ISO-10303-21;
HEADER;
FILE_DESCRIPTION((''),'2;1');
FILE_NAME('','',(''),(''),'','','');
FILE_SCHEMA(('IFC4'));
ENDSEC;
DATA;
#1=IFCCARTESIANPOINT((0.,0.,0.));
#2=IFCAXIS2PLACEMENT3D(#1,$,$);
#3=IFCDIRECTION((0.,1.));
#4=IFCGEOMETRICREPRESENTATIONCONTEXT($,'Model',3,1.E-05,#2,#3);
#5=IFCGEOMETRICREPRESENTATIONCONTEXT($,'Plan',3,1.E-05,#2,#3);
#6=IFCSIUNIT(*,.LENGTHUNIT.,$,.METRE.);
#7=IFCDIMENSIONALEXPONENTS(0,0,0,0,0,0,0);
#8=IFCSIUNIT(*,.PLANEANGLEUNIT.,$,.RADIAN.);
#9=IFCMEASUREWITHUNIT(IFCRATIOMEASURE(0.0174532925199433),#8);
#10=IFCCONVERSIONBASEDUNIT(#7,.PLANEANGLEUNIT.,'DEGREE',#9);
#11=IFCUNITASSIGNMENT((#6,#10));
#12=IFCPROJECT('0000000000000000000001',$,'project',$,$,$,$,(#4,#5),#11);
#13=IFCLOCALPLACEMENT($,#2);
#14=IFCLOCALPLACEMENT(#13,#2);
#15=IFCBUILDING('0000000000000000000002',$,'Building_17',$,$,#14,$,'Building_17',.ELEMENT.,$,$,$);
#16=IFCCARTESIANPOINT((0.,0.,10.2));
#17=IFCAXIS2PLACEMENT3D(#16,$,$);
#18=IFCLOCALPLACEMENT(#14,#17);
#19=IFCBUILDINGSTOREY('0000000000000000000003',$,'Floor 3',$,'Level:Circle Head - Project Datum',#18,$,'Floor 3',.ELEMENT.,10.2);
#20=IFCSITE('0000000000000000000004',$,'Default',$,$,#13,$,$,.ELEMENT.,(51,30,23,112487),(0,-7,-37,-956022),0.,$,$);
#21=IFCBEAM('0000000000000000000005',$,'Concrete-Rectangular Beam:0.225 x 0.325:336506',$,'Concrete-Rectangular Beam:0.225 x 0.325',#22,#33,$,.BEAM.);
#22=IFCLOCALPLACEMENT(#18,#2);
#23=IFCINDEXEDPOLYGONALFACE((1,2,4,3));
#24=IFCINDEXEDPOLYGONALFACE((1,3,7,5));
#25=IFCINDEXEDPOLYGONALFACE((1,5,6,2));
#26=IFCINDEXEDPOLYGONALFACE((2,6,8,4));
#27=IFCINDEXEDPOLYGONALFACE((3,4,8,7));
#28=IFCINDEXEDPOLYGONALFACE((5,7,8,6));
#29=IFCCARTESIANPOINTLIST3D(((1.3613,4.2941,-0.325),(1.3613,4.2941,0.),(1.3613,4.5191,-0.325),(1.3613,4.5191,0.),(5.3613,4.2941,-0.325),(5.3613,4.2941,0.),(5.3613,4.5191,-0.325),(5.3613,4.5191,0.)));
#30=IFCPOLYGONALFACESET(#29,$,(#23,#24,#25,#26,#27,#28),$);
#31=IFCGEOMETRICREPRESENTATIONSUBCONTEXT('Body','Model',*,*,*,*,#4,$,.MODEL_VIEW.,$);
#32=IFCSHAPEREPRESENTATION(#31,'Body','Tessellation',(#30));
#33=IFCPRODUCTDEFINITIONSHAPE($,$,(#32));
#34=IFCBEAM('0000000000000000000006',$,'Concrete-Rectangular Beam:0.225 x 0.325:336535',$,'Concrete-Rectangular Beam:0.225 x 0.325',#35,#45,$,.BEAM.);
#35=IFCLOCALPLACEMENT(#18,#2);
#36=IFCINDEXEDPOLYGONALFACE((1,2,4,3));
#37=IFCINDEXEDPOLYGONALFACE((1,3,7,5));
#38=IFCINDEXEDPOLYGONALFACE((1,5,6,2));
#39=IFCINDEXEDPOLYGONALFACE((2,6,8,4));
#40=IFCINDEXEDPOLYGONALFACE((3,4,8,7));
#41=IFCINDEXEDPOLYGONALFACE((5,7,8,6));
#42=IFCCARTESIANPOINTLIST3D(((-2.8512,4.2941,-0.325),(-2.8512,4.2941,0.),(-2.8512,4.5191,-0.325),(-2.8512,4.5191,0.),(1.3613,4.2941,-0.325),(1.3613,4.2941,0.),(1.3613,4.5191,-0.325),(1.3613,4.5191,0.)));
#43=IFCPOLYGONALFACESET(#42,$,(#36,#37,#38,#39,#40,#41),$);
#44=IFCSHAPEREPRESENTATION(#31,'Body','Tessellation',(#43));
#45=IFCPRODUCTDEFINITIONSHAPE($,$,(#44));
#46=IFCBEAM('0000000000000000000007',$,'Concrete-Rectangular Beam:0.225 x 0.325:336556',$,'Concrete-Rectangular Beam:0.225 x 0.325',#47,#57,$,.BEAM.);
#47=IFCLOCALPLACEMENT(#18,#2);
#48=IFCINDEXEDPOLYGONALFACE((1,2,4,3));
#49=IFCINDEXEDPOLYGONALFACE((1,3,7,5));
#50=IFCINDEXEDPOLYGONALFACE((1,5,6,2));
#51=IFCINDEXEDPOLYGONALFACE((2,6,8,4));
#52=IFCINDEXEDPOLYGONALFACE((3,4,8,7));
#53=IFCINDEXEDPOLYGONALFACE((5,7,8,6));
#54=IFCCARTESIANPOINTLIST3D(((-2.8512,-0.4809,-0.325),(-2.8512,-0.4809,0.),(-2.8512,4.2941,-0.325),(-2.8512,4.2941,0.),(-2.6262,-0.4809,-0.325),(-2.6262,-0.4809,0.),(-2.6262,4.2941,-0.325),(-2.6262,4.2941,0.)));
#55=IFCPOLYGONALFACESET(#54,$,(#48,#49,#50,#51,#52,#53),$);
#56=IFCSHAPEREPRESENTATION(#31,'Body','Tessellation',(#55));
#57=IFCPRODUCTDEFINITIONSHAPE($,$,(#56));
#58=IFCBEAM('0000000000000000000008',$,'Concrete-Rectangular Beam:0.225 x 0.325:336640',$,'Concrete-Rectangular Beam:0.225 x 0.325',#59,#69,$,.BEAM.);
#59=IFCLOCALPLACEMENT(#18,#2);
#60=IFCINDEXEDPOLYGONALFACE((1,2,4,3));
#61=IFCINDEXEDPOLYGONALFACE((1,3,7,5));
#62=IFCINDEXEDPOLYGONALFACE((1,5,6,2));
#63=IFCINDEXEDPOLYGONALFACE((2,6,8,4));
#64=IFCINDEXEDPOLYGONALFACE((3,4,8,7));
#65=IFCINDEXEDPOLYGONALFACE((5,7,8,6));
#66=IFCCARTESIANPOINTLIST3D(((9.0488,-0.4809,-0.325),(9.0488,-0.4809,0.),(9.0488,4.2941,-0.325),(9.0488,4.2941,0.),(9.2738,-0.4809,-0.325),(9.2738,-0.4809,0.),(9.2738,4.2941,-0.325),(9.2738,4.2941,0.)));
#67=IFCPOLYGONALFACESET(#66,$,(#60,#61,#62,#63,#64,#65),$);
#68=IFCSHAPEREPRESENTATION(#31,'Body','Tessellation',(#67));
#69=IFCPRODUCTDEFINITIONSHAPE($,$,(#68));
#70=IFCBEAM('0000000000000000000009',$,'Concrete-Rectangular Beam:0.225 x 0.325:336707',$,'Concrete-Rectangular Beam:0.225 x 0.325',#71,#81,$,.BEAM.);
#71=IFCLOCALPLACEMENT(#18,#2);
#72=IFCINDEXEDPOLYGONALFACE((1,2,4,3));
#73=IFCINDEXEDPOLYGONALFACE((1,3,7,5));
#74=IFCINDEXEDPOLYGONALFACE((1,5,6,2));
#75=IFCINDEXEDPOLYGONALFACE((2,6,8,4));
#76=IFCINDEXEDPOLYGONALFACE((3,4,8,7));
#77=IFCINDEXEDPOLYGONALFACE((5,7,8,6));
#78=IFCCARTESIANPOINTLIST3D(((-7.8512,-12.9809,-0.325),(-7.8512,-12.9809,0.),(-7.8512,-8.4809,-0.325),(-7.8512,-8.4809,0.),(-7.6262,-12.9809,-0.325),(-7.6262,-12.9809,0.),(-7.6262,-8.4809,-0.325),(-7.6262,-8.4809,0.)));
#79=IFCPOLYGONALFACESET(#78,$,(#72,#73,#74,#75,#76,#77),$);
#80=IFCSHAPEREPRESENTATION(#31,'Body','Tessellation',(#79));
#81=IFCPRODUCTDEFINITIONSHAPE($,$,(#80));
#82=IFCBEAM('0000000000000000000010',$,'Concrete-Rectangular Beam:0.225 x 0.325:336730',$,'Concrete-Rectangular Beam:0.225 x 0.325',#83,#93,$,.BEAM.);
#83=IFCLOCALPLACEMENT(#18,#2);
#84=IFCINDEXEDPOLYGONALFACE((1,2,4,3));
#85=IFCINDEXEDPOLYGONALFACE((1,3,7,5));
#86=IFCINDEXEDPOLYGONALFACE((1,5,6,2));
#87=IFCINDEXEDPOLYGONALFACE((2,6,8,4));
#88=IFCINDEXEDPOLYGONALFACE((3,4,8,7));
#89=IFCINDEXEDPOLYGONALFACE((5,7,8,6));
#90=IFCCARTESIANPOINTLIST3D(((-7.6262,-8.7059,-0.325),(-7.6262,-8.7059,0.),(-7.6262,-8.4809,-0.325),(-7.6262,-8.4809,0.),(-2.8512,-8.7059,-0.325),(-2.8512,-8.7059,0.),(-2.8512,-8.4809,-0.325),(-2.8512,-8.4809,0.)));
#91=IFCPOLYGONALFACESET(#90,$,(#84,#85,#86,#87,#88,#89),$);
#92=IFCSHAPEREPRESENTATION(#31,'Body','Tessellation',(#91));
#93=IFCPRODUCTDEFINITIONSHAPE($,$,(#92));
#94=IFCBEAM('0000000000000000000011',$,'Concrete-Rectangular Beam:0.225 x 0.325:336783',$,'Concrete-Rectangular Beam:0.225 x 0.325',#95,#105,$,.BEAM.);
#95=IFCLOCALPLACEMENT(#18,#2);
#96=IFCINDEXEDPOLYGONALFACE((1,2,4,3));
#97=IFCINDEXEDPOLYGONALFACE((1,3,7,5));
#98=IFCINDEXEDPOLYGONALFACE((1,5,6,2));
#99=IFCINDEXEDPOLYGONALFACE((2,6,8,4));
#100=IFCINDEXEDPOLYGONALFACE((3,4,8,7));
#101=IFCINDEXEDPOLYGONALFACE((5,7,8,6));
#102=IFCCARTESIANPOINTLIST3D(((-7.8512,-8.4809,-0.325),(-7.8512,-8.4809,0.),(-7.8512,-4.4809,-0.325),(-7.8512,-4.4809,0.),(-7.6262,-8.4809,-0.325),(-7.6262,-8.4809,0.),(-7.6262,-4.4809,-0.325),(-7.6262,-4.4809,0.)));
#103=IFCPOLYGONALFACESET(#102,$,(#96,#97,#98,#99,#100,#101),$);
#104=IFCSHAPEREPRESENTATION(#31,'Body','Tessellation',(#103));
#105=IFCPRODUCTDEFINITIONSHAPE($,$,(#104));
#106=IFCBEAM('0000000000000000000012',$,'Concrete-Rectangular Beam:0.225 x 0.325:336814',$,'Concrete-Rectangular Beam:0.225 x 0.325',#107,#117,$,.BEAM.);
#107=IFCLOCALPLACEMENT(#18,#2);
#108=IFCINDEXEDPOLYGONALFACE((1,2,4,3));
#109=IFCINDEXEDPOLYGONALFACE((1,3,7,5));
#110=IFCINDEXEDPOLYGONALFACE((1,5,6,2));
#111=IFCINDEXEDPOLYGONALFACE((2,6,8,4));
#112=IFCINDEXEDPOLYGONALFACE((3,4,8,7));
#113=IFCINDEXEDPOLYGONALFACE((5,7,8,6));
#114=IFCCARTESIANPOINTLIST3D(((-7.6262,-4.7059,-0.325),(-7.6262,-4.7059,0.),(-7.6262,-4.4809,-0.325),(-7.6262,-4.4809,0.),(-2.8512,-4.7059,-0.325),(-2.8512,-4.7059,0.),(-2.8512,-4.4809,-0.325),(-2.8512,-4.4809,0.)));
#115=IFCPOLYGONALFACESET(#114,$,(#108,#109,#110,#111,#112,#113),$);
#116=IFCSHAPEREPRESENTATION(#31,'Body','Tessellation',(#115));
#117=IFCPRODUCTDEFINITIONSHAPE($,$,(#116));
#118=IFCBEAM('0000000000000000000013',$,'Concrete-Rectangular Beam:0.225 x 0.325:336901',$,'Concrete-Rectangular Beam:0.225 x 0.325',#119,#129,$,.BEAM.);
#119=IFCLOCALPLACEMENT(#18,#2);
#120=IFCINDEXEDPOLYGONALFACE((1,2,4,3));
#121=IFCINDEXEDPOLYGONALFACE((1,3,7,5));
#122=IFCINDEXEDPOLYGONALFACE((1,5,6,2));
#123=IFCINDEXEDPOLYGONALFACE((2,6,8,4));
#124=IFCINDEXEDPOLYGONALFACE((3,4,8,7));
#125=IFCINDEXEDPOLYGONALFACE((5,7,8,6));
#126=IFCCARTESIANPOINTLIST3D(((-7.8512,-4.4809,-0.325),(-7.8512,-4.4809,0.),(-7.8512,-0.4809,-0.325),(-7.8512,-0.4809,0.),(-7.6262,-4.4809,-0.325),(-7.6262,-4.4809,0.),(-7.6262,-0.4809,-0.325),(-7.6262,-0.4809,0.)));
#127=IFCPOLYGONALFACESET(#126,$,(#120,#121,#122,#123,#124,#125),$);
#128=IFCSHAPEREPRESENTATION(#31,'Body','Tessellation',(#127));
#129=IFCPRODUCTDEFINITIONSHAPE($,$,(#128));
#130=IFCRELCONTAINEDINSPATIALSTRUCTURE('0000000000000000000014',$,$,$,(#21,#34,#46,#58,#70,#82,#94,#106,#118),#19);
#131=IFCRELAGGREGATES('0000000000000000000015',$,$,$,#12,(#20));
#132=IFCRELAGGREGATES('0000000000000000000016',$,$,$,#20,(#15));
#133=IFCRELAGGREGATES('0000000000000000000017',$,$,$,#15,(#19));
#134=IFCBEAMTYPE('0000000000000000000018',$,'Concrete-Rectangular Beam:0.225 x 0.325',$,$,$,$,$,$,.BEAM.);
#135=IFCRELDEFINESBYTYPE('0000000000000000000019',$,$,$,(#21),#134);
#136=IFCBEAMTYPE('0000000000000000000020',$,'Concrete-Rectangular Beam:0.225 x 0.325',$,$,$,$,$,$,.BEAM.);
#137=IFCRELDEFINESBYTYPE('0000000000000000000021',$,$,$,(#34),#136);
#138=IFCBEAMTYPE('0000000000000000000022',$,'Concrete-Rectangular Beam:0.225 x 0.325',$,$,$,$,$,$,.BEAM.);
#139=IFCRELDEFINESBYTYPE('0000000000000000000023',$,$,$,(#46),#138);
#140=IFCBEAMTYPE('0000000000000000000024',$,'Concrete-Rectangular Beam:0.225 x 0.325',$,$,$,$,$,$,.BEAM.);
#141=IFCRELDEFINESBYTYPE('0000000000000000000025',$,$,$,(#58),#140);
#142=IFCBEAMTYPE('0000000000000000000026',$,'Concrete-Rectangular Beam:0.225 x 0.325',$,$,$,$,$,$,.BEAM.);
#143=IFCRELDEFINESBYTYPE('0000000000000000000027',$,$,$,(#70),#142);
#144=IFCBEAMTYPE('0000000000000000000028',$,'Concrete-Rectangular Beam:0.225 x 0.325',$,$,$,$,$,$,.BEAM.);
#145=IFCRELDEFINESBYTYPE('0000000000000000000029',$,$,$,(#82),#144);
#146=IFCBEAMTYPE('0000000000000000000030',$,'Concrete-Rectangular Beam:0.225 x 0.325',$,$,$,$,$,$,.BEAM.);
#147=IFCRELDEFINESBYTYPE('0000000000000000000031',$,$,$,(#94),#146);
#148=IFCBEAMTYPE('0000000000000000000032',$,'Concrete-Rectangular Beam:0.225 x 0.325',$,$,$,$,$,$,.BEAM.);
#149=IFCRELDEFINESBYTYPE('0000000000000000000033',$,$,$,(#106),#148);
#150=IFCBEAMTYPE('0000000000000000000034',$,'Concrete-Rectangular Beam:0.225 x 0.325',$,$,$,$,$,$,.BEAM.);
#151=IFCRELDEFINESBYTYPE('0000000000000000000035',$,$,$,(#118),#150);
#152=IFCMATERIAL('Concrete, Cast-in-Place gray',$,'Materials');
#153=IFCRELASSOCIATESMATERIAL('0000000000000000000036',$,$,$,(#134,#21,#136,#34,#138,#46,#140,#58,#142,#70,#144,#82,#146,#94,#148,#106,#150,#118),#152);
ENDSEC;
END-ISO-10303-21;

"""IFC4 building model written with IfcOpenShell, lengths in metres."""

from ifc_helpers import new_model, entity, si_unit, converted_unit, direction, frame, origin, place, context, subcontext, project, spatial, indexed_curve, outline, extrude, source, transform, mapped, material, type_object, type_shapes, element, save


model = new_model("IFC4")

# Units and contexts
model_context = context("Model", 3, precision=1e-05, world=origin(), true_north=direction((0.0, 1.0)))
plan_context = context("Plan", 3, precision=1e-05, world=origin(), true_north=direction((0.0, 1.0)))
body_context = subcontext(model_context, "Body", "Model", "MODEL_VIEW")
ifc_project = project(units=[si_unit("LENGTHUNIT", "METRE"), converted_unit("PLANEANGLEUNIT", "DEGREE", entity("IfcRatioMeasure", 0.0174532925199433), si_unit("PLANEANGLEUNIT", "RADIAN"), dimensions=[0, 0, 0, 0, 0, 0, 0])], contexts=[model_context, plan_context])

# Site, building, storey
site_placement = place(None, origin())
site = spatial("IfcSite", under=ifc_project, at=site_placement, Name="Default", CompositionType="ELEMENT", RefLatitude=(51, 30, 23, 112487), RefLongitude=(0, -7, -37, -956022), RefElevation=0.0)
building_placement = place(site_placement, origin())
building = spatial("IfcBuilding", under=site, at=building_placement, Name="Building_17", LongName="Building_17", CompositionType="ELEMENT")
storey_placement = place(building_placement, frame((0.0, 0.0, 10.2)))
storey = spatial("IfcBuildingStorey", under=building, at=storey_placement, Name="Floor 3", ObjectType="Level:Circle Head - Project Datum", LongName="Floor 3", CompositionType="ELEMENT", Elevation=10.2)

# Beams
ifc_material_1 = material(Name="Concrete, Cast-in-Place gray", Category="Materials")
beam_type_1 = type_object("IfcBeamType", Name="Concrete-Rectangular Beam:0.225 x 0.325", PredefinedType="BEAM", material=ifc_material_1)
shared_shape_1 = source(origin(), body_context, "Body", "SweptSolid", [
    extrude(outline(indexed_curve([(-0.1625, -0.1125), (0.1625, -0.1125), (0.1625, 0.1125), (-0.1625, 0.1125), (-0.1625, -0.1125)], self_intersect=False)), frame((5.3613, 4.4066, 10.0375), z_axis=(-1.0, 0.0, 0.0), x_axis=(0.0, 0.0, -1.0)), (0.0, 0.0, 1.0), 4.0),
])
type_shapes(beam_type_1, [shared_shape_1])
beam_1_placement = place(storey_placement, frame((0.0, 0.0, -10.2)))
element("IfcBeam", 1, at=beam_1_placement, inside=storey, type_object=beam_type_1, material=ifc_material_1, Name="Concrete-Rectangular Beam:0.225 x 0.325:336506", ObjectType="Concrete-Rectangular Beam:0.225 x 0.325", PredefinedType="BEAM", context=body_context, shape_type="MappedRepresentation", body=[
    mapped(shared_shape_1, transform((0.0, 0.0, 0.0), scale=1.0)),
])
beam_type_2 = type_object("IfcBeamType", Name="Concrete-Rectangular Beam:0.225 x 0.325", PredefinedType="BEAM", material=ifc_material_1)
shared_shape_2 = source(origin(), body_context, "Body", "SweptSolid", [
    extrude(outline(indexed_curve([(-0.1625, -0.1125), (0.1625, -0.1125), (0.1625, 0.1125), (-0.1625, 0.1125), (-0.1625, -0.1125)], self_intersect=False)), frame((1.3613, 4.4066, 10.0375), z_axis=(-1.0, 0.0, 0.0), x_axis=(0.0, 0.0, -1.0)), (0.0, 0.0, 1.0), 4.2125),
])
type_shapes(beam_type_2, [shared_shape_2])
beam_2_placement = place(storey_placement, frame((0.0, 0.0, -10.2)))
element("IfcBeam", 2, at=beam_2_placement, inside=storey, type_object=beam_type_2, material=ifc_material_1, Name="Concrete-Rectangular Beam:0.225 x 0.325:336535", ObjectType="Concrete-Rectangular Beam:0.225 x 0.325", PredefinedType="BEAM", context=body_context, shape_type="MappedRepresentation", body=[
    mapped(shared_shape_2, transform((0.0, 0.0, 0.0), scale=1.0)),
])
beam_type_3 = type_object("IfcBeamType", Name="Concrete-Rectangular Beam:0.225 x 0.325", PredefinedType="BEAM", material=ifc_material_1)
shared_shape_3 = source(origin(), body_context, "Body", "SweptSolid", [
    extrude(outline(indexed_curve([(-0.1125, -0.1625), (0.1125, -0.1625), (0.1125, 0.1625), (-0.1125, 0.1625), (-0.1125, -0.1625)], self_intersect=False)), frame((-2.7387, 4.2941, 10.0375), z_axis=(0.0, -1.0, 0.0), x_axis=(-1.0, 0.0, 0.0)), (0.0, 0.0, 1.0), 4.775),
])
type_shapes(beam_type_3, [shared_shape_3])
beam_3_placement = place(storey_placement, frame((0.0, 0.0, -10.2)))
element("IfcBeam", 3, at=beam_3_placement, inside=storey, type_object=beam_type_3, material=ifc_material_1, Name="Concrete-Rectangular Beam:0.225 x 0.325:336556", ObjectType="Concrete-Rectangular Beam:0.225 x 0.325", PredefinedType="BEAM", context=body_context, shape_type="MappedRepresentation", body=[
    mapped(shared_shape_3, transform((0.0, 0.0, 0.0), scale=1.0)),
])
beam_type_4 = type_object("IfcBeamType", Name="Concrete-Rectangular Beam:0.225 x 0.325", PredefinedType="BEAM", material=ifc_material_1)
shared_shape_4 = source(origin(), body_context, "Body", "SweptSolid", [
    extrude(outline(indexed_curve([(-0.1125, -0.1625), (0.1125, -0.1625), (0.1125, 0.1625), (-0.1125, 0.1625), (-0.1125, -0.1625)], self_intersect=False)), frame((9.1613, 4.2941, 10.0375), z_axis=(0.0, -1.0, 0.0), x_axis=(-1.0, 0.0, 0.0)), (0.0, 0.0, 1.0), 4.775),
])
type_shapes(beam_type_4, [shared_shape_4])
beam_4_placement = place(storey_placement, frame((0.0, 0.0, -10.2)))
element("IfcBeam", 4, at=beam_4_placement, inside=storey, type_object=beam_type_4, material=ifc_material_1, Name="Concrete-Rectangular Beam:0.225 x 0.325:336640", ObjectType="Concrete-Rectangular Beam:0.225 x 0.325", PredefinedType="BEAM", context=body_context, shape_type="MappedRepresentation", body=[
    mapped(shared_shape_4, transform((0.0, 0.0, 0.0), scale=1.0)),
])
beam_type_5 = type_object("IfcBeamType", Name="Concrete-Rectangular Beam:0.225 x 0.325", PredefinedType="BEAM", material=ifc_material_1)
shared_shape_5 = source(origin(), body_context, "Body", "SweptSolid", [
    extrude(outline(indexed_curve([(-0.1125, -0.1625), (0.1125, -0.1625), (0.1125, 0.1625), (-0.1125, 0.1625), (-0.1125, -0.1625)], self_intersect=False)), frame((-7.7387, -12.9809, 10.0375), z_axis=(0.0, 1.0, 0.0), x_axis=(-1.0, 0.0, 0.0)), (0.0, 0.0, 1.0), 4.5),
])
type_shapes(beam_type_5, [shared_shape_5])
beam_5_placement = place(storey_placement, frame((0.0, 0.0, -10.2)))
element("IfcBeam", 5, at=beam_5_placement, inside=storey, type_object=beam_type_5, material=ifc_material_1, Name="Concrete-Rectangular Beam:0.225 x 0.325:336707", ObjectType="Concrete-Rectangular Beam:0.225 x 0.325", PredefinedType="BEAM", context=body_context, shape_type="MappedRepresentation", body=[
    mapped(shared_shape_5, transform((0.0, 0.0, 0.0), scale=1.0)),
])
beam_type_6 = type_object("IfcBeamType", Name="Concrete-Rectangular Beam:0.225 x 0.325", PredefinedType="BEAM", material=ifc_material_1)
shared_shape_6 = source(origin(), body_context, "Body", "SweptSolid", [
    extrude(outline(indexed_curve([(-0.1625, -0.1125), (0.1625, -0.1125), (0.1625, 0.1125), (-0.1625, 0.1125), (-0.1625, -0.1125)], self_intersect=False)), frame((-7.6262, -8.5934, 10.0375), z_axis=(1.0, 0.0, 0.0), x_axis=(0.0, 0.0, -1.0)), (0.0, 0.0, 1.0), 4.775),
])
type_shapes(beam_type_6, [shared_shape_6])
beam_6_placement = place(storey_placement, frame((0.0, 0.0, -10.2)))
element("IfcBeam", 6, at=beam_6_placement, inside=storey, type_object=beam_type_6, material=ifc_material_1, Name="Concrete-Rectangular Beam:0.225 x 0.325:336730", ObjectType="Concrete-Rectangular Beam:0.225 x 0.325", PredefinedType="BEAM", context=body_context, shape_type="MappedRepresentation", body=[
    mapped(shared_shape_6, transform((0.0, 0.0, 0.0), scale=1.0)),
])
beam_type_7 = type_object("IfcBeamType", Name="Concrete-Rectangular Beam:0.225 x 0.325", PredefinedType="BEAM", material=ifc_material_1)
shared_shape_7 = source(origin(), body_context, "Body", "SweptSolid", [
    extrude(outline(indexed_curve([(-0.1125, -0.1625), (0.1125, -0.1625), (0.1125, 0.1625), (-0.1125, 0.1625), (-0.1125, -0.1625)], self_intersect=False)), frame((-7.7387, -4.4809, 10.0375), z_axis=(0.0, -1.0, 0.0), x_axis=(-1.0, 0.0, 0.0)), (0.0, 0.0, 1.0), 4.0),
])
type_shapes(beam_type_7, [shared_shape_7])
beam_7_placement = place(storey_placement, frame((0.0, 0.0, -10.2)))
element("IfcBeam", 7, at=beam_7_placement, inside=storey, type_object=beam_type_7, material=ifc_material_1, Name="Concrete-Rectangular Beam:0.225 x 0.325:336783", ObjectType="Concrete-Rectangular Beam:0.225 x 0.325", PredefinedType="BEAM", context=body_context, shape_type="MappedRepresentation", body=[
    mapped(shared_shape_7, transform((0.0, 0.0, 0.0), scale=1.0)),
])
beam_type_8 = type_object("IfcBeamType", Name="Concrete-Rectangular Beam:0.225 x 0.325", PredefinedType="BEAM", material=ifc_material_1)
shared_shape_8 = source(origin(), body_context, "Body", "SweptSolid", [
    extrude(outline(indexed_curve([(-0.1625, -0.1125), (0.1625, -0.1125), (0.1625, 0.1125), (-0.1625, 0.1125), (-0.1625, -0.1125)], self_intersect=False)), frame((-7.6262, -4.5934, 10.0375), z_axis=(1.0, 0.0, 0.0), x_axis=(0.0, 0.0, -1.0)), (0.0, 0.0, 1.0), 4.775),
])
type_shapes(beam_type_8, [shared_shape_8])
beam_8_placement = place(storey_placement, frame((0.0, 0.0, -10.2)))
element("IfcBeam", 8, at=beam_8_placement, inside=storey, type_object=beam_type_8, material=ifc_material_1, Name="Concrete-Rectangular Beam:0.225 x 0.325:336814", ObjectType="Concrete-Rectangular Beam:0.225 x 0.325", PredefinedType="BEAM", context=body_context, shape_type="MappedRepresentation", body=[
    mapped(shared_shape_8, transform((0.0, 0.0, 0.0), scale=1.0)),
])
beam_type_9 = type_object("IfcBeamType", Name="Concrete-Rectangular Beam:0.225 x 0.325", PredefinedType="BEAM", material=ifc_material_1)
shared_shape_9 = source(origin(), body_context, "Body", "SweptSolid", [
    extrude(outline(indexed_curve([(-0.1125, -0.1625), (0.1125, -0.1625), (0.1125, 0.1625), (-0.1125, 0.1625), (-0.1125, -0.1625)], self_intersect=False)), frame((-7.7387, -4.4809, 10.0375), z_axis=(0.0, 1.0, 0.0), x_axis=(-1.0, 0.0, 0.0)), (0.0, 0.0, 1.0), 4.0),
])
type_shapes(beam_type_9, [shared_shape_9])
beam_9_placement = place(storey_placement, frame((0.0, 0.0, -10.2)))
element("IfcBeam", 9, at=beam_9_placement, inside=storey, type_object=beam_type_9, material=ifc_material_1, Name="Concrete-Rectangular Beam:0.225 x 0.325:336901", ObjectType="Concrete-Rectangular Beam:0.225 x 0.325", PredefinedType="BEAM", context=body_context, shape_type="MappedRepresentation", body=[
    mapped(shared_shape_9, transform((0.0, 0.0, 0.0), scale=1.0)),
])

save(model, "model.ifc")
